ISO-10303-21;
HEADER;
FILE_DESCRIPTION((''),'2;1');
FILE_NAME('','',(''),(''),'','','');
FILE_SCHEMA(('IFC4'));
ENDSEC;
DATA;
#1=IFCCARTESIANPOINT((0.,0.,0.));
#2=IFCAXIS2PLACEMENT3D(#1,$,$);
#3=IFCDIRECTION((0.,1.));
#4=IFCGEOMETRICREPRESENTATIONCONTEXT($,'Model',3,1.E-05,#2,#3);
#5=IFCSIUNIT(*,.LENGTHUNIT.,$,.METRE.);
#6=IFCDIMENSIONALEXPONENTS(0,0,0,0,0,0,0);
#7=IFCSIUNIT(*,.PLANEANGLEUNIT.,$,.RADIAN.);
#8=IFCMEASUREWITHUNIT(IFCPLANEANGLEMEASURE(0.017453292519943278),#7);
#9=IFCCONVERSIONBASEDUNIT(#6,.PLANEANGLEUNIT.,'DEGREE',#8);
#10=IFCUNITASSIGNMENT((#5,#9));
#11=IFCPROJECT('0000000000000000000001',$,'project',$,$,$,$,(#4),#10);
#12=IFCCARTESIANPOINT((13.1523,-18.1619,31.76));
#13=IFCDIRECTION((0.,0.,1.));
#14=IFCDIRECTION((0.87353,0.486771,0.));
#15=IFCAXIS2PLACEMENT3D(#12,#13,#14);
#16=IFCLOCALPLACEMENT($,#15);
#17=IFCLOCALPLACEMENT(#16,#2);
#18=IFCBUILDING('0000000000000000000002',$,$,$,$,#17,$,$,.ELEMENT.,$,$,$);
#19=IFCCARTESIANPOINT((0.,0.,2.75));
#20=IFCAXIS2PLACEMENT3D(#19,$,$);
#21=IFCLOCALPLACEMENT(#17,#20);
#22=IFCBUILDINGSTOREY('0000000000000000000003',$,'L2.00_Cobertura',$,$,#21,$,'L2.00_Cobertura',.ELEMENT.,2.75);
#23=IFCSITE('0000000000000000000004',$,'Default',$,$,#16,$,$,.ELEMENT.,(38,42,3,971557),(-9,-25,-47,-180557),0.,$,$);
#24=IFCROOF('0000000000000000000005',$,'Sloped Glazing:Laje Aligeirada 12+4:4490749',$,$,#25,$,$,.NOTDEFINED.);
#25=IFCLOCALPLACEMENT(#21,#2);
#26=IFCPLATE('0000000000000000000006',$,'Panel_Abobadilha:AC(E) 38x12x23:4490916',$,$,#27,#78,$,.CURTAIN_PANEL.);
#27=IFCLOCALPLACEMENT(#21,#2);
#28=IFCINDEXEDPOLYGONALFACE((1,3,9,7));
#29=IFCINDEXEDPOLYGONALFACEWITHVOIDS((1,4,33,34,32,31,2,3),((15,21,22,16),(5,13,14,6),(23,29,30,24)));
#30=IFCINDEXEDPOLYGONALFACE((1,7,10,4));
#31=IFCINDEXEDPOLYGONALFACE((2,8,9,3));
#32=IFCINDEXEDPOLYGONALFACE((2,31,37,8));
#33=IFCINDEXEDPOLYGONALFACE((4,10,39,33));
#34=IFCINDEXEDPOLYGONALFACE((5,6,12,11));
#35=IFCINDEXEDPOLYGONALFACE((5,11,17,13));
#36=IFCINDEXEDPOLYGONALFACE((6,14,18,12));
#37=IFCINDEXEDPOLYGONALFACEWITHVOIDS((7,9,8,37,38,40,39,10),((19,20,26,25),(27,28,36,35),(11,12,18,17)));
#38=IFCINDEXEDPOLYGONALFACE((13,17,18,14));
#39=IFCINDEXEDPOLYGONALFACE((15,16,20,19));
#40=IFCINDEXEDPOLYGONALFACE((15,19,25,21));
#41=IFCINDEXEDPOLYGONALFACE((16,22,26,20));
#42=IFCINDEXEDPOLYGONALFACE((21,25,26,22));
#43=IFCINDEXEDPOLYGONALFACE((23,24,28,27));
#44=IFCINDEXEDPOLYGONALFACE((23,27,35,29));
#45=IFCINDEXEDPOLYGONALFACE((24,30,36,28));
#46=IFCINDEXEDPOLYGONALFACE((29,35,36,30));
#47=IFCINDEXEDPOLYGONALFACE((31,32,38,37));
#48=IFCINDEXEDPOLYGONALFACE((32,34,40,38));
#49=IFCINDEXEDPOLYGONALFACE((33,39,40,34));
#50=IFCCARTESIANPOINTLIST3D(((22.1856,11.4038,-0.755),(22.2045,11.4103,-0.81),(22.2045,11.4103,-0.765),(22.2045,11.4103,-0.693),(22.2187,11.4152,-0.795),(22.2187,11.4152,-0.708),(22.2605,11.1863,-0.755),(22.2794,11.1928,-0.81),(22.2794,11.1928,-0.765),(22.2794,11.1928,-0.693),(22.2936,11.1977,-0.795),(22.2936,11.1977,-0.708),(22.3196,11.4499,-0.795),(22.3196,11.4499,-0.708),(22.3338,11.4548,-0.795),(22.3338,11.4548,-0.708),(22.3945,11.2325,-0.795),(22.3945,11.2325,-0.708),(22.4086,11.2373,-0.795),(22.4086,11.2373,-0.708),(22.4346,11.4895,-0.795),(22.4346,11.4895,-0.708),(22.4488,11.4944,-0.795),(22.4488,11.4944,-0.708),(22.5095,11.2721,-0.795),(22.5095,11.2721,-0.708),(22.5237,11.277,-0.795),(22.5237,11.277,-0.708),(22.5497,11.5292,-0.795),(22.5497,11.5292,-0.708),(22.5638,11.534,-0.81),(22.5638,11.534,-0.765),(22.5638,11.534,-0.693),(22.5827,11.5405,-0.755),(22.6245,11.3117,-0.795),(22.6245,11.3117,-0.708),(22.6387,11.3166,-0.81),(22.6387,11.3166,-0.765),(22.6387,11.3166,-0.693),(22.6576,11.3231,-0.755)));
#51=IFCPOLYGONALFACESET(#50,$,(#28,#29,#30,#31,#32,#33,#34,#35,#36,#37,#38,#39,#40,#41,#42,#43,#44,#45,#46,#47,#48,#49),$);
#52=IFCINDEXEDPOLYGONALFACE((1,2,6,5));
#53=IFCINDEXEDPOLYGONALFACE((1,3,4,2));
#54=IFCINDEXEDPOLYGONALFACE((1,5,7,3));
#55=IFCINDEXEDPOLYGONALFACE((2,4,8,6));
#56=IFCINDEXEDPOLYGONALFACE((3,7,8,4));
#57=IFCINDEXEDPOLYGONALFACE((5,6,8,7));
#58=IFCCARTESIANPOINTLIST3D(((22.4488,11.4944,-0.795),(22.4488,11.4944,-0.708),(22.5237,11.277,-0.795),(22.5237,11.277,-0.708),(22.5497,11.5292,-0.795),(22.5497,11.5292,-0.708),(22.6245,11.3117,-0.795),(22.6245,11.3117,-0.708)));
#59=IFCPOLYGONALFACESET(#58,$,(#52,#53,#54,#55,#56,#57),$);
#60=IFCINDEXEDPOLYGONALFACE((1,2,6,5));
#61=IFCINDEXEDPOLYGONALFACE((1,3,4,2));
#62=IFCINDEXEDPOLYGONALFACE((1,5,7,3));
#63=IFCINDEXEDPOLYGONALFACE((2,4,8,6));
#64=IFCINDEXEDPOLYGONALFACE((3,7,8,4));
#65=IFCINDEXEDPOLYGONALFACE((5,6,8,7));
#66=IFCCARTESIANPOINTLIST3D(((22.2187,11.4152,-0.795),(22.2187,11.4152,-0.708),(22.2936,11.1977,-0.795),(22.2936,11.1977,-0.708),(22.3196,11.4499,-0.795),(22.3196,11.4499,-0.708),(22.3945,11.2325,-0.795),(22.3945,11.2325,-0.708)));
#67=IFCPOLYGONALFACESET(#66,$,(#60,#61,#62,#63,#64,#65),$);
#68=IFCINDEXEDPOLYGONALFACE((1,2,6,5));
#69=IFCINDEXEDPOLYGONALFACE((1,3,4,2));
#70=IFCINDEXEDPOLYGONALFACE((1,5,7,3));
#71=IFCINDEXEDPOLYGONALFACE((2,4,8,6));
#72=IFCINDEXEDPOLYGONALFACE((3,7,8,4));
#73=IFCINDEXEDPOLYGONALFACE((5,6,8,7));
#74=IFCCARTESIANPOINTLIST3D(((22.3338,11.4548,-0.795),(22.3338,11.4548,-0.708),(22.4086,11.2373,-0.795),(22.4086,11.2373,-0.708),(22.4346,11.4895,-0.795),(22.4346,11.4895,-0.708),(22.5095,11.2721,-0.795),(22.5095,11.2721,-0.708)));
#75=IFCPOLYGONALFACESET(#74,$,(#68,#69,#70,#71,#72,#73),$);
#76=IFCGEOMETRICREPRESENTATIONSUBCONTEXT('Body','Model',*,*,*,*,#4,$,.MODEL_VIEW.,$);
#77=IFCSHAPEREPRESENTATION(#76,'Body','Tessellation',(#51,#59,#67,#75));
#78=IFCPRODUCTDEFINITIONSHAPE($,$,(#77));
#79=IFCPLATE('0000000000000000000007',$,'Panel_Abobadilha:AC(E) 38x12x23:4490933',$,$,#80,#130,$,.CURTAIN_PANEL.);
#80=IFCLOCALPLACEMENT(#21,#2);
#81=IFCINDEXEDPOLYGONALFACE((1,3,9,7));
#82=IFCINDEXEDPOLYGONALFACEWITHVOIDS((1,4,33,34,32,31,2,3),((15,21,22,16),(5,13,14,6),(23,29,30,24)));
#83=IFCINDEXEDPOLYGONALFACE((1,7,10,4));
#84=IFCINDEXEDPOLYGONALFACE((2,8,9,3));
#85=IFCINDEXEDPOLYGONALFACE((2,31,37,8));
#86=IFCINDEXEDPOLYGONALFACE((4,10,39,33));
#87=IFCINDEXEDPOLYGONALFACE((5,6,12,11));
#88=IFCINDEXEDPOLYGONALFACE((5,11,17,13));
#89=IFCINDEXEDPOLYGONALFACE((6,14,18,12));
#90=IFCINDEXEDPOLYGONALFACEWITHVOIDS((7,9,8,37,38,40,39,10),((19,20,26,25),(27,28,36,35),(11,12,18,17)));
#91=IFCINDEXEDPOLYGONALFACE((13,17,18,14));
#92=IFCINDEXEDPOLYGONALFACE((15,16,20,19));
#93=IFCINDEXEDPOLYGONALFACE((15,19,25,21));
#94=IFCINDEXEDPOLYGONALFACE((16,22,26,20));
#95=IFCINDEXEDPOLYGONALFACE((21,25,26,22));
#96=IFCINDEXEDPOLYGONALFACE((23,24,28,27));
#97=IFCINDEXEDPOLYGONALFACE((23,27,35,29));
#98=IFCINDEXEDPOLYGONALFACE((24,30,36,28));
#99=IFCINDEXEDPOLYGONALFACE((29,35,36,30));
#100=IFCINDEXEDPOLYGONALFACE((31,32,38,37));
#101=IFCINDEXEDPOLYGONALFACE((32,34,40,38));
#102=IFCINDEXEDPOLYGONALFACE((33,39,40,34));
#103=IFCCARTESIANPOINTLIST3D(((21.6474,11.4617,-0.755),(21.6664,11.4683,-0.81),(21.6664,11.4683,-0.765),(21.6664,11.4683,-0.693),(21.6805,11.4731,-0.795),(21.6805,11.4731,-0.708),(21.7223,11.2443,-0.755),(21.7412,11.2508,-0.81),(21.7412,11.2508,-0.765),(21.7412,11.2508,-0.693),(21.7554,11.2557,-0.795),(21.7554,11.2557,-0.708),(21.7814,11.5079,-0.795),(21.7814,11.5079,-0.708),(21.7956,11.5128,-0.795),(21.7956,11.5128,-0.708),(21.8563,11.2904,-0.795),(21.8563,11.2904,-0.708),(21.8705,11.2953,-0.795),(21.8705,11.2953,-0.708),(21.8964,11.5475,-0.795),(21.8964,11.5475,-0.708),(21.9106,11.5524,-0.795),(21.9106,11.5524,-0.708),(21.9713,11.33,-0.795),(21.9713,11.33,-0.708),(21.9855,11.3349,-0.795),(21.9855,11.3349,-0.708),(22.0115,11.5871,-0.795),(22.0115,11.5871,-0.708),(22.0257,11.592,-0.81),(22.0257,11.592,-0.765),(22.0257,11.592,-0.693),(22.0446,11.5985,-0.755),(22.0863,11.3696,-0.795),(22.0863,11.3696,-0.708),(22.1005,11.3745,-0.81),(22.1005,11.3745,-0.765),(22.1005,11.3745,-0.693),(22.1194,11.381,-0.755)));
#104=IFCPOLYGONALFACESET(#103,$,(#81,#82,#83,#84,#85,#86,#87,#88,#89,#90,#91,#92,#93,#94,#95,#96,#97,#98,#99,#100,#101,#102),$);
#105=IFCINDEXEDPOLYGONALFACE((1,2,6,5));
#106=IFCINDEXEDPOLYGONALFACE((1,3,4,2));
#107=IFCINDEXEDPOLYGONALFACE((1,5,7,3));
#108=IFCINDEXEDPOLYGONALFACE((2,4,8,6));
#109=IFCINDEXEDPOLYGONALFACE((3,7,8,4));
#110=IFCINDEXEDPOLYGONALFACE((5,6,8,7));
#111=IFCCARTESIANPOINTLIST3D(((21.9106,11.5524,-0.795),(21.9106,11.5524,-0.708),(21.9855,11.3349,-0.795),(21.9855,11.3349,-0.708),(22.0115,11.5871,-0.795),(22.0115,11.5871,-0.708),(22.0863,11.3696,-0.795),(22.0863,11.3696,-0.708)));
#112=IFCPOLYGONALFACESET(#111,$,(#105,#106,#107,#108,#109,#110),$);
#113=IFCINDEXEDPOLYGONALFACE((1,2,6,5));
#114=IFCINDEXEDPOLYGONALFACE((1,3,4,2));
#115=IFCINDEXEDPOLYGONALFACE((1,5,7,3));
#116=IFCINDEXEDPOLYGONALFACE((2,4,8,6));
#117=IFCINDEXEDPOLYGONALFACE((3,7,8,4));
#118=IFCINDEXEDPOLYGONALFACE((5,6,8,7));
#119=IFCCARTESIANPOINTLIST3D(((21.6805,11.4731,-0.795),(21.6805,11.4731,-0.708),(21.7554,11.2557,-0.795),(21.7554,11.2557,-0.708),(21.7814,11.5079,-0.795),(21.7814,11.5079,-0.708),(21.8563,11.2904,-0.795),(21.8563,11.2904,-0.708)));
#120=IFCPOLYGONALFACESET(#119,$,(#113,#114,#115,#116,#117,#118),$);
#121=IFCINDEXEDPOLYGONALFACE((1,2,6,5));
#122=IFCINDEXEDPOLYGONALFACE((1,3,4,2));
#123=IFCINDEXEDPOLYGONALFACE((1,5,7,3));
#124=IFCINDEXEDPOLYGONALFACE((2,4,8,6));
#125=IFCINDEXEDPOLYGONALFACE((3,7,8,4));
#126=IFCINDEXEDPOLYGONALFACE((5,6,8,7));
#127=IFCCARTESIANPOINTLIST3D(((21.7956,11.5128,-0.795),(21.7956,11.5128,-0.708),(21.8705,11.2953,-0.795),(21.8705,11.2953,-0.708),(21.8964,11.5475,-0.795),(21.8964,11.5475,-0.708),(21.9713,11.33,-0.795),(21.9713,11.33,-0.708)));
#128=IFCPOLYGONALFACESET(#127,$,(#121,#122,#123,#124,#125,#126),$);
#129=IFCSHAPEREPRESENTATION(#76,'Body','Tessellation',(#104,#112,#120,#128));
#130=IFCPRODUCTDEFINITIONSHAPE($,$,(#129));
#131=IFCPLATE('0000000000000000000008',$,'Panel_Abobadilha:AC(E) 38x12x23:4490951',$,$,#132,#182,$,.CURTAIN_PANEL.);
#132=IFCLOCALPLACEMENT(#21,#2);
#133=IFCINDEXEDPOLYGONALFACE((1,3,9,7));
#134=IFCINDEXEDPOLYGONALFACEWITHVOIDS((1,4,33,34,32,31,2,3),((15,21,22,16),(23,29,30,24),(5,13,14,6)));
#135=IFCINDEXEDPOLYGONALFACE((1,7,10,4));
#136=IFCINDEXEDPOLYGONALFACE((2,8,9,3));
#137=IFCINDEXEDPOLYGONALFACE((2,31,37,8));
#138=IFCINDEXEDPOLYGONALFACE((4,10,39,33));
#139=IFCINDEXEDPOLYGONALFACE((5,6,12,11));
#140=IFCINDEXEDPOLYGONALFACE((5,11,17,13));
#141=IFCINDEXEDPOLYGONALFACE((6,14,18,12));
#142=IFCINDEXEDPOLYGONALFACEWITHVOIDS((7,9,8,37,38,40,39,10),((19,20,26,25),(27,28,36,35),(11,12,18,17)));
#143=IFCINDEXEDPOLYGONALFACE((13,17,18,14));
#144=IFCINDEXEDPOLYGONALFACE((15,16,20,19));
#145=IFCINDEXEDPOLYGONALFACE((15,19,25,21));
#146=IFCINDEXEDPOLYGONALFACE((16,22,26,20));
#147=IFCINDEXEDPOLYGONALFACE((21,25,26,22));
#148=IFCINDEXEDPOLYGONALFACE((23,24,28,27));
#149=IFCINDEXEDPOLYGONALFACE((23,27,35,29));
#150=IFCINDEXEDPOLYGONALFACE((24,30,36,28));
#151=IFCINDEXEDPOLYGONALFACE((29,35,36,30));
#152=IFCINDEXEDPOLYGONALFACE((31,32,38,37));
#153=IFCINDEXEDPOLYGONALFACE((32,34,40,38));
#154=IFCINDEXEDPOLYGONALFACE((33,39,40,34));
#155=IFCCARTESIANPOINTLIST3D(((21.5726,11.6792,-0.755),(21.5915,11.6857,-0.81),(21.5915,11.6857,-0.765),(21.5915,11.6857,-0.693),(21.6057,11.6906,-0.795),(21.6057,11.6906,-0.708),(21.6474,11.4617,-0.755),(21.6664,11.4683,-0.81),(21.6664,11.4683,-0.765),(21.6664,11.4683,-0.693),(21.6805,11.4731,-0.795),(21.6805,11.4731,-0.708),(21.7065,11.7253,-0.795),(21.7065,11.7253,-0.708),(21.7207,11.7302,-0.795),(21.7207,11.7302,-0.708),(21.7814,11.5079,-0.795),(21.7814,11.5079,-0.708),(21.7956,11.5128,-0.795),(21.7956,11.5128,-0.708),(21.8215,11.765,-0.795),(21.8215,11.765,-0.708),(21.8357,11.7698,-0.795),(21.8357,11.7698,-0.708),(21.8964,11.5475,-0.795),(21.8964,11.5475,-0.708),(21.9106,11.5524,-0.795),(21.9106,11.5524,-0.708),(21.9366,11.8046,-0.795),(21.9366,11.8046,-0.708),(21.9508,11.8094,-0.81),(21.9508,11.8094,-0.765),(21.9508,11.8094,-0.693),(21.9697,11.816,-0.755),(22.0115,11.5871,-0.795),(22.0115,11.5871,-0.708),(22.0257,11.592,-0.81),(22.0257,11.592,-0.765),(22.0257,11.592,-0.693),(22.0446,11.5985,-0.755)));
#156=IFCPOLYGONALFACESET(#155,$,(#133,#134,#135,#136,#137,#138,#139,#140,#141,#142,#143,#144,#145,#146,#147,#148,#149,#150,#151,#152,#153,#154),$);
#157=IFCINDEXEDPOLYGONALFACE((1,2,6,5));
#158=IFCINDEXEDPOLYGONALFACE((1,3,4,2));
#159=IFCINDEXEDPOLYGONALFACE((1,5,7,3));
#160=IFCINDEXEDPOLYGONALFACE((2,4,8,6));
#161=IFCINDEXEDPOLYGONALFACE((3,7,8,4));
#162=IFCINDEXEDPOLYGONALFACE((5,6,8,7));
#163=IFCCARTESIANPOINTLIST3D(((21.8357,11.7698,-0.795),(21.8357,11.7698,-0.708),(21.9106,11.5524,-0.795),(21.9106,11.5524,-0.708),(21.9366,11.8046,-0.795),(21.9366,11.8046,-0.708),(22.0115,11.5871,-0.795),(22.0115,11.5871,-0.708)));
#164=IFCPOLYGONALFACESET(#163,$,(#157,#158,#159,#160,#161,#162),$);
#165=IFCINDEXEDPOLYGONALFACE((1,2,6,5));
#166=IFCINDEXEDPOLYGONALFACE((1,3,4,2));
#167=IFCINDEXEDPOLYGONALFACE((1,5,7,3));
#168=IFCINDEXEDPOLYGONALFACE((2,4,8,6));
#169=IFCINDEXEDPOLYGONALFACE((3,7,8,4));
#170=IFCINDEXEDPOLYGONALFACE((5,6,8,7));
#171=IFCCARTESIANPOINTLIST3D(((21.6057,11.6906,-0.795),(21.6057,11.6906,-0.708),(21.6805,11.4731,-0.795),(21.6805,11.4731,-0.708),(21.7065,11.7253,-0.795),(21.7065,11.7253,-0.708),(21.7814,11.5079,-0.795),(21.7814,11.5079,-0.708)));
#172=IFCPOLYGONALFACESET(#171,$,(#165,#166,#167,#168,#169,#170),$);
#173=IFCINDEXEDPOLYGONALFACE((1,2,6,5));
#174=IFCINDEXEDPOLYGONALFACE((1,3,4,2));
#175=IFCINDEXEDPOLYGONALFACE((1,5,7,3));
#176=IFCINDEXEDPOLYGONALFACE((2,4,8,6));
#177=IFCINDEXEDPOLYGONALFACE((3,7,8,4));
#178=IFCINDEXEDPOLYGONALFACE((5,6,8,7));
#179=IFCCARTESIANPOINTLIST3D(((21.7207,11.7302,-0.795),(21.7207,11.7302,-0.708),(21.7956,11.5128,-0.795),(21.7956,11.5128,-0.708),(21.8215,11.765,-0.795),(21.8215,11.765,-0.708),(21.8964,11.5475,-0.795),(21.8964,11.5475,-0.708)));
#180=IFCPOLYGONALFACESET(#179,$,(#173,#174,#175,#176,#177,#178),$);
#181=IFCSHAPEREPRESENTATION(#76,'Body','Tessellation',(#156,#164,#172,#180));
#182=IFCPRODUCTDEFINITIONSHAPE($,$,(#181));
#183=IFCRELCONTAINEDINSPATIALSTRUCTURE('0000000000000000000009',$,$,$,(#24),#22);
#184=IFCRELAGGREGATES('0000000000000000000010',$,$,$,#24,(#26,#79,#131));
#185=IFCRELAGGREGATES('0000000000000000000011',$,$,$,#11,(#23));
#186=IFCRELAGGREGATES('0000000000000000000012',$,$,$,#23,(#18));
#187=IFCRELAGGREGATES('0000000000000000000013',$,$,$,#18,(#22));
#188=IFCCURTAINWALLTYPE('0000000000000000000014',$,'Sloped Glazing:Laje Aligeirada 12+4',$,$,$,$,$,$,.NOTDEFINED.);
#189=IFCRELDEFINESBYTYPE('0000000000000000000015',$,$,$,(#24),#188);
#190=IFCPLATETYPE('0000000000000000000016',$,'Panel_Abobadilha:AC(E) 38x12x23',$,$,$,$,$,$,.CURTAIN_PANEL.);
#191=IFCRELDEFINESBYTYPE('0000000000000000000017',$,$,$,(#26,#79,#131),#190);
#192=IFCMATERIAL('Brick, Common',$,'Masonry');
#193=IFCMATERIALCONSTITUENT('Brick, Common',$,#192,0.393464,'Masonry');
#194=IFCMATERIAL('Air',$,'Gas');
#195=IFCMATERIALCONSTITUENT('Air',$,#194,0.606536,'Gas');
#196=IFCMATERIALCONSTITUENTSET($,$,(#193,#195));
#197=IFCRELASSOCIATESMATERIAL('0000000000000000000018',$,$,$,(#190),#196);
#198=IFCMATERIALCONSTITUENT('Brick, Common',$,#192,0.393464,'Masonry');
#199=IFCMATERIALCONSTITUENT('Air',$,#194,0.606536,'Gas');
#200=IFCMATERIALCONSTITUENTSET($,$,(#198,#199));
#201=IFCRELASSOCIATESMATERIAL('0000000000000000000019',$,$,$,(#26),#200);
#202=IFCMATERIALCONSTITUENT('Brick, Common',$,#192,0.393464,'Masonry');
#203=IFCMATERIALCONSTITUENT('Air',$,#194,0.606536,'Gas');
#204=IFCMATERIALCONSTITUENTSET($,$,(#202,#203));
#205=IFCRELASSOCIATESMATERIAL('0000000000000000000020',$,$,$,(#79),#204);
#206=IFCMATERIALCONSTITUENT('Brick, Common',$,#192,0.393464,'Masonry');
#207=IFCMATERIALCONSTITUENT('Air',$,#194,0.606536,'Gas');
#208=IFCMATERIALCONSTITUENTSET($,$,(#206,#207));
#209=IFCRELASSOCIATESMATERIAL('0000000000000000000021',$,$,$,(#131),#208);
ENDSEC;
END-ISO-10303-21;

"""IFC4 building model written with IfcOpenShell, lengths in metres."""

from ifc_helpers import new_model, entity, si_unit, converted_unit, direction, frame, origin, place, context, subcontext, project, spatial, indexed_curve, outline, extrude, source, transform, mapped, material, constituent, constituent_set, type_object, type_shapes, element, aggregate, save


model = new_model("IFC4")

# Units and contexts
model_context = context("Model", 3, precision=1e-05, world=origin(), true_north=direction((0.0, 1.0)))
body_context = subcontext(model_context, "Body", "Model", "MODEL_VIEW")
ifc_project = project(units=[si_unit("LENGTHUNIT", "METRE"), converted_unit("PLANEANGLEUNIT", "DEGREE", entity("IfcPlaneAngleMeasure", 0.017453292519943278), si_unit("PLANEANGLEUNIT", "RADIAN"), dimensions=[0, 0, 0, 0, 0, 0, 0])], contexts=[model_context])

# Site, building, storey
site_placement = place(None, frame((13.1523, -18.1619, 31.76), z_axis=(0.0, 0.0, 1.0), x_axis=(0.87353, 0.486771, 0.0)))
site = spatial("IfcSite", under=ifc_project, at=site_placement, Name="Default", CompositionType="ELEMENT", RefLatitude=(38, 42, 3, 971557), RefLongitude=(-9, -25, -47, -180557), RefElevation=0.0)
building_placement = place(site_placement, origin())
building = spatial("IfcBuilding", under=site, at=building_placement, CompositionType="ELEMENT")
storey_placement = place(building_placement, frame((0.0, 0.0, 2.75)))
storey = spatial("IfcBuildingStorey", under=building, at=storey_placement, Name="L2.00_Cobertura", LongName="L2.00_Cobertura", CompositionType="ELEMENT", Elevation=2.75)

# Roof
curtain_wall_type = type_object("IfcCurtainWallType", Name="Sloped Glazing:Laje Aligeirada 12+4", PredefinedType="NOTDEFINED")
roof_placement = place(storey_placement, frame((0.0, 0.0, -2.75)))
roof = element("IfcRoof", 1, at=roof_placement, inside=storey, type_object=curtain_wall_type, Name="Sloped Glazing:Laje Aligeirada 12+4:4490749", PredefinedType="NOTDEFINED")

# Plates
ifc_material_1 = material(Name="Brick, Common", Category="Masonry")
ifc_material_2 = material(Name="Air", Category="Gas")
ifc_constituent_1 = constituent(ifc_material_1, Name="Brick, Common", Category="Masonry", fraction=0.393464)
ifc_constituent_2 = constituent(ifc_material_2, Name="Air", Category="Gas", fraction=0.606536)
ifc_constituent_set_1 = constituent_set(constituents=[ifc_constituent_1, ifc_constituent_2])
plate_type_1 = type_object("IfcPlateType", Name="Panel_Abobadilha:AC(E) 38x12x23", PredefinedType="CURTAIN_PANEL", material=ifc_constituent_set_1)
shared_shape_1 = source(origin(), body_context, "Body", "SweptSolid", [
    extrude(outline(indexed_curve([(-0.19, -0.0543), (0.19, -0.0543), (0.19, -0.0093), (0.21, 0.0007), (0.19, 0.0628), (-0.19, 0.0628), (-0.21, 0.0007), (-0.19, -0.0093), (-0.19, -0.0543)], self_intersect=False), holes=[indexed_curve([(-0.0683, 0.0477), (-0.0683, -0.0393), (-0.175, -0.0393), (-0.175, 0.0477), (-0.0683, 0.0477)], self_intersect=False), indexed_curve([(0.0533, 0.0477), (0.0533, -0.0393), (-0.0533, -0.0393), (-0.0533, 0.0477), (0.0533, 0.0477)], self_intersect=False), indexed_curve([(0.175, 0.0477), (0.175, -0.0393), (0.0683, -0.0393), (0.0683, 0.0477), (0.175, 0.0477)], self_intersect=False)]), frame((0.0, 0.0543, 0.0)), (0.0, 0.0, 1.0), 0.23),
    extrude(outline(indexed_curve([(-0.0533, -0.0435), (0.0533, -0.0435), (0.0533, 0.0435), (-0.0533, 0.0435), (-0.0533, -0.0435)], self_intersect=False)), frame((0.1217, 0.0585, 0.0), z_axis=(0.0, 0.0, 1.0), x_axis=(-1.0, 0.0, 0.0)), (0.0, 0.0, 1.0), 0.23),
    extrude(outline(indexed_curve([(-0.0533, -0.0435), (0.0533, -0.0435), (0.0533, 0.0435), (-0.0533, 0.0435), (-0.0533, -0.0435)], self_intersect=False)), frame((-0.1217, 0.0585, 0.0), z_axis=(0.0, 0.0, 1.0), x_axis=(-1.0, 0.0, 0.0)), (0.0, 0.0, 1.0), 0.23),
    extrude(outline(indexed_curve([(-0.0533, -0.0435), (0.0533, -0.0435), (0.0533, 0.0435), (-0.0533, 0.0435), (-0.0533, -0.0435)], self_intersect=False)), frame((0.0, 0.0585, 0.0), z_axis=(0.0, 0.0, 1.0), x_axis=(-1.0, 0.0, 0.0)), (0.0, 0.0, 1.0), 0.23),
])
type_shapes(plate_type_1, [shared_shape_1])
ifc_constituent_3 = constituent(ifc_material_1, Name="Brick, Common", Category="Masonry", fraction=0.393464)
ifc_constituent_4 = constituent(ifc_material_2, Name="Air", Category="Gas", fraction=0.606536)
ifc_constituent_set_2 = constituent_set(constituents=[ifc_constituent_3, ifc_constituent_4])
plate_1_placement = place(roof_placement, frame((22.3842, 11.4722, 1.94), z_axis=(0.325568, -0.945519, 0.0), x_axis=(0.945519, 0.325568, 0.0)))
plate_1 = element("IfcPlate", 2, at=plate_1_placement, type_object=plate_type_1, material=ifc_constituent_set_2, Name="Panel_Abobadilha:AC(E) 38x12x23:4490916", PredefinedType="CURTAIN_PANEL", context=body_context, shape_type="MappedRepresentation", body=[
    mapped(shared_shape_1, transform((0.0, 0.0, 0.0), scale=1.0)),
])
ifc_constituent_5 = constituent(ifc_material_1, Name="Brick, Common", Category="Masonry", fraction=0.393464)
ifc_constituent_6 = constituent(ifc_material_2, Name="Air", Category="Gas", fraction=0.606536)
ifc_constituent_set_3 = constituent_set(constituents=[ifc_constituent_5, ifc_constituent_6])
plate_2_placement = place(roof_placement, frame((21.846, 11.5301, 1.94), z_axis=(0.325568, -0.945519, 0.0), x_axis=(0.945519, 0.325568, 0.0)))
plate_2 = element("IfcPlate", 3, at=plate_2_placement, type_object=plate_type_1, material=ifc_constituent_set_3, Name="Panel_Abobadilha:AC(E) 38x12x23:4490933", PredefinedType="CURTAIN_PANEL", context=body_context, shape_type="MappedRepresentation", body=[
    mapped(shared_shape_1, transform((0.0, 0.0, 0.0), scale=1.0)),
])
ifc_constituent_7 = constituent(ifc_material_1, Name="Brick, Common", Category="Masonry", fraction=0.393464)
ifc_constituent_8 = constituent(ifc_material_2, Name="Air", Category="Gas", fraction=0.606536)
ifc_constituent_set_4 = constituent_set(constituents=[ifc_constituent_7, ifc_constituent_8])
plate_3_placement = place(roof_placement, frame((21.7711, 11.7476, 1.94), z_axis=(0.325568, -0.945519, 0.0), x_axis=(0.945519, 0.325568, 0.0)))
plate_3 = element("IfcPlate", 4, at=plate_3_placement, type_object=plate_type_1, material=ifc_constituent_set_4, Name="Panel_Abobadilha:AC(E) 38x12x23:4490951", PredefinedType="CURTAIN_PANEL", context=body_context, shape_type="MappedRepresentation", body=[
    mapped(shared_shape_1, transform((0.0, 0.0, 0.0), scale=1.0)),
])
aggregate(roof, [plate_1, plate_2, plate_3])

save(model, "model.ifc")
